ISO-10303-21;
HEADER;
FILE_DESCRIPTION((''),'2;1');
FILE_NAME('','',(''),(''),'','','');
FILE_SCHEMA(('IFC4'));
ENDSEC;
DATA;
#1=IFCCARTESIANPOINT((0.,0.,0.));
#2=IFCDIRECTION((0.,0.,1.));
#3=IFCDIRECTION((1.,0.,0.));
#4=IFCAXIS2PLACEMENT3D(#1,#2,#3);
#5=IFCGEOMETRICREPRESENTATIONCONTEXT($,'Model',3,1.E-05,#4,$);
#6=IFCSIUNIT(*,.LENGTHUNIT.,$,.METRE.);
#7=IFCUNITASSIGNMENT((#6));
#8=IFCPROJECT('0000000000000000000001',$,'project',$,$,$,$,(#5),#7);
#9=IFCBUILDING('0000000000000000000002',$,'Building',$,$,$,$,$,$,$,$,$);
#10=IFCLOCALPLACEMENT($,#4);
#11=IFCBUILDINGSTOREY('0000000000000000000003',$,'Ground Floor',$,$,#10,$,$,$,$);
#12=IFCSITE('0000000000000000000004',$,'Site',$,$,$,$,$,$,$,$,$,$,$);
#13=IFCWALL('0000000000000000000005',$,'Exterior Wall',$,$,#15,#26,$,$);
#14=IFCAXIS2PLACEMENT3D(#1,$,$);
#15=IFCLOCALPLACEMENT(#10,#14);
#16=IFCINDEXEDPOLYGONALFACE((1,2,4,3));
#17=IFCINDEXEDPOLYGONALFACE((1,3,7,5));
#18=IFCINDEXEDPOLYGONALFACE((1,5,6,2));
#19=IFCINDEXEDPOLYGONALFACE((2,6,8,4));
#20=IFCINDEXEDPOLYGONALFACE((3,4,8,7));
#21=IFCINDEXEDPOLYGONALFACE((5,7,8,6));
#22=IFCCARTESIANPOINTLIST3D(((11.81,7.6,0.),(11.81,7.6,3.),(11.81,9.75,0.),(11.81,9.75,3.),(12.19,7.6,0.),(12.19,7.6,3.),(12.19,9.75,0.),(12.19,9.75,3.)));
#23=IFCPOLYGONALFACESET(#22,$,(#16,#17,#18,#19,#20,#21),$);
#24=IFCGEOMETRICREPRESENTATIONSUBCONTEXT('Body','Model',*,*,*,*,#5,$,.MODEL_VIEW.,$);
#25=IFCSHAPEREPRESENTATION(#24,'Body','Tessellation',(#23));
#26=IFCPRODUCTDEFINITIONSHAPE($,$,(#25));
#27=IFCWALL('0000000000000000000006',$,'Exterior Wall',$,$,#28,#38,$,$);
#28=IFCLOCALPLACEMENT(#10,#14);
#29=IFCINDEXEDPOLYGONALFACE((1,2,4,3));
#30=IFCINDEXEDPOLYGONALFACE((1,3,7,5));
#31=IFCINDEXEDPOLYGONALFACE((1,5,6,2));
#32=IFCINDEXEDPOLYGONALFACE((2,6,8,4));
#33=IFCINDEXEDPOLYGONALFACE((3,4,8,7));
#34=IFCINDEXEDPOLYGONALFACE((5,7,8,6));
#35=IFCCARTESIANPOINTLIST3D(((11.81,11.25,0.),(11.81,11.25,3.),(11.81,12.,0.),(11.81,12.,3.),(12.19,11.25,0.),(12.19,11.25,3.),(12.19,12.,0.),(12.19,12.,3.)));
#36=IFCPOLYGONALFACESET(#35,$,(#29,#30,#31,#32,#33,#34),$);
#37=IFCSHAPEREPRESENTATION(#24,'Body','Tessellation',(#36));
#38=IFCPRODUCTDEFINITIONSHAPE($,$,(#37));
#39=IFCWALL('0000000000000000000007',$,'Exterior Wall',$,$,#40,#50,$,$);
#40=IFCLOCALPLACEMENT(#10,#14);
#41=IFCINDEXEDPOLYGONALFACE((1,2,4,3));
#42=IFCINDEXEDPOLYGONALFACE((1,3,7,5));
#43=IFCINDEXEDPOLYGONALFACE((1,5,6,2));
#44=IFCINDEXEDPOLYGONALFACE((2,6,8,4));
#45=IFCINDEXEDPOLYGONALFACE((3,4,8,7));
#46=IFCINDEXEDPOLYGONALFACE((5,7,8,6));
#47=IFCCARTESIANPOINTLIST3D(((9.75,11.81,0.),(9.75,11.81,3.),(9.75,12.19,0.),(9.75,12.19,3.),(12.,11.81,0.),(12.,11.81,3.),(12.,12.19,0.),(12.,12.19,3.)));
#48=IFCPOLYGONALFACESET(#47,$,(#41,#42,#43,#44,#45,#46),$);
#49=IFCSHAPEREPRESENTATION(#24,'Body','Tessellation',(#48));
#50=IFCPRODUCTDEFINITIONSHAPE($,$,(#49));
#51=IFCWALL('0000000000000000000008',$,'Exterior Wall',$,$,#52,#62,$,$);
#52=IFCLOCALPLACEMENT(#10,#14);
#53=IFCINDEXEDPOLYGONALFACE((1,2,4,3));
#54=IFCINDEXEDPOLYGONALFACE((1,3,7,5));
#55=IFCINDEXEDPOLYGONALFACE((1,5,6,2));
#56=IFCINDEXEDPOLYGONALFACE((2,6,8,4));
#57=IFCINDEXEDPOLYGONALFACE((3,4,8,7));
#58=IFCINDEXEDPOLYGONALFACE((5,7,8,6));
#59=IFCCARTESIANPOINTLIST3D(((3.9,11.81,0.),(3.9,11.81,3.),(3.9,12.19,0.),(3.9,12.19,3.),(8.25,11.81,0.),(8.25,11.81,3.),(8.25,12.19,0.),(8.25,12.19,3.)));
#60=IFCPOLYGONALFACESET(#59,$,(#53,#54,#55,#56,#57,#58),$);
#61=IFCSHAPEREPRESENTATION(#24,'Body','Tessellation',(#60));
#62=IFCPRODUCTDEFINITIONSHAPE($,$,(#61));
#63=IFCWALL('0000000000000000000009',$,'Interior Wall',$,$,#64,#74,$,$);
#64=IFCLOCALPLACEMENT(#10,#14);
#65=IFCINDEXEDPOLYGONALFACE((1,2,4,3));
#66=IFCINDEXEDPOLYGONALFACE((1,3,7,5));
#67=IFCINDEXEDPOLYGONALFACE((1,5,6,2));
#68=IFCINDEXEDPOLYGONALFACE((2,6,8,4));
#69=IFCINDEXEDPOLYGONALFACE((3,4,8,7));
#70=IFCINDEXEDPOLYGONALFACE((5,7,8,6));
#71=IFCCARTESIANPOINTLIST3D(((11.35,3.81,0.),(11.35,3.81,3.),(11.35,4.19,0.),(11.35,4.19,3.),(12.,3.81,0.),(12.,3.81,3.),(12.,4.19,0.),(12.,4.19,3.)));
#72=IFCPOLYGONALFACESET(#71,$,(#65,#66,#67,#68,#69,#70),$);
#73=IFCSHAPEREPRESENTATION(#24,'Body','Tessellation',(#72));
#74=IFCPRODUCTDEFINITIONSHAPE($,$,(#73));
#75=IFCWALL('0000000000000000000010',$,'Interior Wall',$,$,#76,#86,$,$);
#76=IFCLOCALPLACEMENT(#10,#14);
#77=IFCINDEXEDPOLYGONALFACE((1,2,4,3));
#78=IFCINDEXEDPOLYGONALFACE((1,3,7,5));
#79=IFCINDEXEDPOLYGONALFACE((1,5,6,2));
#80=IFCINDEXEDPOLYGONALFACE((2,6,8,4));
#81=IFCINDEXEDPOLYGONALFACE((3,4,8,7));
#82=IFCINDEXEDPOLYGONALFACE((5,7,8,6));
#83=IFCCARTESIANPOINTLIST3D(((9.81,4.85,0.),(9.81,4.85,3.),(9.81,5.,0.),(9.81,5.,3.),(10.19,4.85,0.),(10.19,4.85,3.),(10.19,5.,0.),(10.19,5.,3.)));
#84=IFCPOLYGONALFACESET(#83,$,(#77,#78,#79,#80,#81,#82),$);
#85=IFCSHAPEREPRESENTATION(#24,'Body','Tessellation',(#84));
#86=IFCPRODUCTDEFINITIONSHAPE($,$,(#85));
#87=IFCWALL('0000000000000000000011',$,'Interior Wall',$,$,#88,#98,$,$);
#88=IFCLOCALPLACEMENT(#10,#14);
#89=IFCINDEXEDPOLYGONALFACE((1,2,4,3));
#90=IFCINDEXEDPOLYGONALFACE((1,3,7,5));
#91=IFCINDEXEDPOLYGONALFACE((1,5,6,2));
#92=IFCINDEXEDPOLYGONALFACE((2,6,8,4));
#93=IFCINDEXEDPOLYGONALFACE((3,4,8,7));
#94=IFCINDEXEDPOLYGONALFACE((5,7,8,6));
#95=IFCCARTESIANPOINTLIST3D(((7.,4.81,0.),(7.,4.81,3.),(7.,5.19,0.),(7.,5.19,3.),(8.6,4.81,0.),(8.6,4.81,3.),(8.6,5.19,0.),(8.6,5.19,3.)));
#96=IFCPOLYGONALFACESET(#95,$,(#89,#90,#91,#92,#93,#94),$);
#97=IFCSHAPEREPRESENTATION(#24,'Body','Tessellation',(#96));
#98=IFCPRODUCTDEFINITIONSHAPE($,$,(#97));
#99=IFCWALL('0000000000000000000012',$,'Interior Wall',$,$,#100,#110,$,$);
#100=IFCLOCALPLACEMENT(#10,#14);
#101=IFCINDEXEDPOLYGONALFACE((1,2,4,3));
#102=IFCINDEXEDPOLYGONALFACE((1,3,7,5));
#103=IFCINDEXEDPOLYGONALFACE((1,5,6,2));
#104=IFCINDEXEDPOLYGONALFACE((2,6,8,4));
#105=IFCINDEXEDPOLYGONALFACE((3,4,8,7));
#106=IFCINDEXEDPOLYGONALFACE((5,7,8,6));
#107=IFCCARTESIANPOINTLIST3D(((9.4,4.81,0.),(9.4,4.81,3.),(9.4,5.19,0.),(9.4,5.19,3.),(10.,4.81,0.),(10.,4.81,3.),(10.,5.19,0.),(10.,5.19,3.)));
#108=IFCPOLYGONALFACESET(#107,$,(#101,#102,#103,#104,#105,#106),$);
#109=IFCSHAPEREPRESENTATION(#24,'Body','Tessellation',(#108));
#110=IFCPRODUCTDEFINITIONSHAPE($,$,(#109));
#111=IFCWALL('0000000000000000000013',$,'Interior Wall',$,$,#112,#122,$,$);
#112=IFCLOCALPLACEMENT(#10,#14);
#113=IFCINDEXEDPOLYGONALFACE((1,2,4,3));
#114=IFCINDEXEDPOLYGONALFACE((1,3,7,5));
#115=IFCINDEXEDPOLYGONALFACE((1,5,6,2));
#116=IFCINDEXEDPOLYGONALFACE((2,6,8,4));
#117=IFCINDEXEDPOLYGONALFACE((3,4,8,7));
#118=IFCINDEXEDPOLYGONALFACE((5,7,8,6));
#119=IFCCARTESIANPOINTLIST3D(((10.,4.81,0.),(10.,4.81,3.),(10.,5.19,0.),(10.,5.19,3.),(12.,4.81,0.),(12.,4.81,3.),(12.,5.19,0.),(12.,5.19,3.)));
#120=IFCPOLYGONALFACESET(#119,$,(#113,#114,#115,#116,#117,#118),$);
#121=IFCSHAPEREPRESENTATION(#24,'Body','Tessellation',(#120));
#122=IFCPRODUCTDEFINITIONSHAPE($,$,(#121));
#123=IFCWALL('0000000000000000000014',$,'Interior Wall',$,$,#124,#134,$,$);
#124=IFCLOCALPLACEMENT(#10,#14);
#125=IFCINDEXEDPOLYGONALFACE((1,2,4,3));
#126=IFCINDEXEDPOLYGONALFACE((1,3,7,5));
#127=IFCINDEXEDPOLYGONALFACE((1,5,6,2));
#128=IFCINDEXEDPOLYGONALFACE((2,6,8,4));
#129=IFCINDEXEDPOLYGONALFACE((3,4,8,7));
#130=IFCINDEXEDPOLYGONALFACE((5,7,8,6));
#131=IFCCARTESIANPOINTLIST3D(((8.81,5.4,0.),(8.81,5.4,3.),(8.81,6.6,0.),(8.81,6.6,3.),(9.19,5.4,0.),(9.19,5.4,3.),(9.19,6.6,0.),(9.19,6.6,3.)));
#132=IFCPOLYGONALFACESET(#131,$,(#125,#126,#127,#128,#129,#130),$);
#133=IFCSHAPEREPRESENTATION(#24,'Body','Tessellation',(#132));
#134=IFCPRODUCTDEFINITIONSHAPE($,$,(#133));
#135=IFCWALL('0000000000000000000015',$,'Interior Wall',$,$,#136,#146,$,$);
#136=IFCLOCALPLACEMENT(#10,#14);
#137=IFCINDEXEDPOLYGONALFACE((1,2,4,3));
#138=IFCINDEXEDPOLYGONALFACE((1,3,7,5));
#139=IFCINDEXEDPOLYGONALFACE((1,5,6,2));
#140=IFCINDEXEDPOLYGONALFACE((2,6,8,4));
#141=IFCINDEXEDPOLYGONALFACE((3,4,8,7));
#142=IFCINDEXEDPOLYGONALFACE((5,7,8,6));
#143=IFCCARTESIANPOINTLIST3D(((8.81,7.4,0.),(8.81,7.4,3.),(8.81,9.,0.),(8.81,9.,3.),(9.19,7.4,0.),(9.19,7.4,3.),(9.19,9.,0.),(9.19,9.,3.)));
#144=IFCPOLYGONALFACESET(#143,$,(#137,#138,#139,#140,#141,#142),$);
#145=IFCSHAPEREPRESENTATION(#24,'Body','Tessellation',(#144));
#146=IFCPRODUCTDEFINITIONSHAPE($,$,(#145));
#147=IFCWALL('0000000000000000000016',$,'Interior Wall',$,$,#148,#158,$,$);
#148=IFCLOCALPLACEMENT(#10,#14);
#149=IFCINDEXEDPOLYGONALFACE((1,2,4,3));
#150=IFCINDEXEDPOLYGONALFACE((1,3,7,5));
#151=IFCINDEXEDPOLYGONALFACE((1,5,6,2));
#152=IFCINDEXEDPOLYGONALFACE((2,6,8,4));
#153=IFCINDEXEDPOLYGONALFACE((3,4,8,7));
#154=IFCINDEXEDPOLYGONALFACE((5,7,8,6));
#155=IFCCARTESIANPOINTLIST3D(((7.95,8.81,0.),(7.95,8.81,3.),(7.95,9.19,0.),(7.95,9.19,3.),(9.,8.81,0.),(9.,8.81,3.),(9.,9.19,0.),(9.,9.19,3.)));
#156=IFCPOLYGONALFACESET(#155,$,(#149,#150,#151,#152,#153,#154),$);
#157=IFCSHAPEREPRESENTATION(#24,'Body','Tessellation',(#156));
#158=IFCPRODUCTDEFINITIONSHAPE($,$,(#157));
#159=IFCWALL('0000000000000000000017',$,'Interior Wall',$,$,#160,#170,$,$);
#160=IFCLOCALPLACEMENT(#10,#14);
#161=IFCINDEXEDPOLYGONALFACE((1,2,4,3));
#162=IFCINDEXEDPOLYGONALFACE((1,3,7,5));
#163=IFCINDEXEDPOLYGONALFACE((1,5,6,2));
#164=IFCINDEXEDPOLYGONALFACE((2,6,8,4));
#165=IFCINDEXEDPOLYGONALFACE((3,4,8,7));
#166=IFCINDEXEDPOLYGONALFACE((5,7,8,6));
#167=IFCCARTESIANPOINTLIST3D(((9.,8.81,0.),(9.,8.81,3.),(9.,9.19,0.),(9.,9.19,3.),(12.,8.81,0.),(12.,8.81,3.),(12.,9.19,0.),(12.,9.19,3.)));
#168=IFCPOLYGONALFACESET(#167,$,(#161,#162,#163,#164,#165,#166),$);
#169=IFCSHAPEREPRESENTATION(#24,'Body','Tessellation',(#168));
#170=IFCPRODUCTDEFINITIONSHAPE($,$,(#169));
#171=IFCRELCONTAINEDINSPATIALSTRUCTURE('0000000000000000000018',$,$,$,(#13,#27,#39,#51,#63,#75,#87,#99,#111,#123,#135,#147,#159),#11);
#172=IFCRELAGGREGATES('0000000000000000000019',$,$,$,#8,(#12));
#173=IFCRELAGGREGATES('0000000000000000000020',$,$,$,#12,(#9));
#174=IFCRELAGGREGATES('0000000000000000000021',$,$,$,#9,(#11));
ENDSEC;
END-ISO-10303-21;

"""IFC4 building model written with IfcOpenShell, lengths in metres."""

from ifc_helpers import new_model, si_unit, frame, origin_with_axes, place, context, subcontext, project, spatial, indexed_curve, outline, extrude, element, save


model = new_model("IFC4")

# Units and contexts
model_context = context("Model", 3, precision=1e-05, world=origin_with_axes())
body_context = subcontext(model_context, "Body", "Model", "MODEL_VIEW")
ifc_project = project(units=[si_unit("LENGTHUNIT", "METRE")], contexts=[model_context])

# Site, building, storey
site = spatial("IfcSite", under=ifc_project, Name="Site")
building = spatial("IfcBuilding", under=site, Name="Building")
storey_placement = place(None, origin_with_axes())
storey = spatial("IfcBuildingStorey", under=building, at=storey_placement, Name="Ground Floor")

# Walls
wall_1_placement = place(storey_placement, frame((12.0, 7.6, 0.0), z_axis=(0.0, 0.0, 1.0), x_axis=(0.0, 1.0, 0.0)))
element("IfcWall", 1, at=wall_1_placement, inside=storey, Name="Exterior Wall", context=body_context, shape_type="SweptSolid", body=[
    extrude(outline(indexed_curve([(0.0, 0.0), (0.0, 0.38), (2.15, 0.38), (2.15, 0.0), (0.0, 0.0)], self_intersect=False)), frame((0.0, -0.19, 0.0), z_axis=(0.0, 0.0, 1.0), x_axis=(1.0, 0.0, 0.0)), (0.0, 0.0, 1.0), 3.0),
])
wall_2_placement = place(storey_placement, frame((12.0, 11.25, 0.0), z_axis=(0.0, 0.0, 1.0), x_axis=(0.0, 1.0, 0.0)))
element("IfcWall", 2, at=wall_2_placement, inside=storey, Name="Exterior Wall", context=body_context, shape_type="SweptSolid", body=[
    extrude(outline(indexed_curve([(0.0, 0.0), (0.0, 0.38), (0.75, 0.38), (0.75, 0.0), (0.0, 0.0)], self_intersect=False)), frame((0.0, -0.19, 0.0), z_axis=(0.0, 0.0, 1.0), x_axis=(1.0, 0.0, 0.0)), (0.0, 0.0, 1.0), 3.0),
])
wall_3_placement = place(storey_placement, frame((12.0, 12.0, 0.0), z_axis=(0.0, 0.0, 1.0), x_axis=(-1.0, 0.0, 0.0)))
element("IfcWall", 3, at=wall_3_placement, inside=storey, Name="Exterior Wall", context=body_context, shape_type="SweptSolid", body=[
    extrude(outline(indexed_curve([(0.0, 0.0), (0.0, 0.38), (2.25, 0.38), (2.25, 0.0), (0.0, 0.0)], self_intersect=False)), frame((0.0, -0.19, 0.0), z_axis=(0.0, 0.0, 1.0), x_axis=(1.0, 0.0, 0.0)), (0.0, 0.0, 1.0), 3.0),
])
wall_4_placement = place(storey_placement, frame((8.25, 12.0, 0.0), z_axis=(0.0, 0.0, 1.0), x_axis=(-1.0, 0.0, 0.0)))
element("IfcWall", 4, at=wall_4_placement, inside=storey, Name="Exterior Wall", context=body_context, shape_type="SweptSolid", body=[
    extrude(outline(indexed_curve([(0.0, 0.0), (0.0, 0.38), (4.35, 0.38), (4.35, 0.0), (0.0, 0.0)], self_intersect=False)), frame((0.0, -0.19, 0.0), z_axis=(0.0, 0.0, 1.0), x_axis=(1.0, 0.0, 0.0)), (0.0, 0.0, 1.0), 3.0),
])
wall_5_placement = place(storey_placement, frame((12.0, 4.0, 0.0), z_axis=(0.0, 0.0, 1.0), x_axis=(-1.0, 0.0, 0.0)))
element("IfcWall", 5, at=wall_5_placement, inside=storey, Name="Interior Wall", context=body_context, shape_type="SweptSolid", body=[
    extrude(outline(indexed_curve([(0.0, 0.0), (0.0, 0.38), (0.65, 0.38), (0.65, 0.0), (0.0, 0.0)], self_intersect=False)), frame((0.0, -0.19, 0.0), z_axis=(0.0, 0.0, 1.0), x_axis=(1.0, 0.0, 0.0)), (0.0, 0.0, 1.0), 3.0),
])
wall_6_placement = place(storey_placement, frame((10.0, 4.85, 0.0), z_axis=(0.0, 0.0, 1.0), x_axis=(0.0, 1.0, 0.0)))
element("IfcWall", 6, at=wall_6_placement, inside=storey, Name="Interior Wall", context=body_context, shape_type="SweptSolid", body=[
    extrude(outline(indexed_curve([(0.0, 0.0), (0.0, 0.38), (0.15, 0.38), (0.15, 0.0), (0.0, 0.0)], self_intersect=False)), frame((0.0, -0.19, 0.0), z_axis=(0.0, 0.0, 1.0), x_axis=(1.0, 0.0, 0.0)), (0.0, 0.0, 1.0), 3.0),
])
wall_7_placement = place(storey_placement, frame((8.6, 5.0, 0.0), z_axis=(0.0, 0.0, 1.0), x_axis=(-1.0, 0.0, 0.0)))
element("IfcWall", 7, at=wall_7_placement, inside=storey, Name="Interior Wall", context=body_context, shape_type="SweptSolid", body=[
    extrude(outline(indexed_curve([(0.0, 0.0), (0.0, 0.38), (1.6, 0.38), (1.6, 0.0), (0.0, 0.0)], self_intersect=False)), frame((0.0, -0.19, 0.0), z_axis=(0.0, 0.0, 1.0), x_axis=(1.0, 0.0, 0.0)), (0.0, 0.0, 1.0), 3.0),
])
wall_8_placement = place(storey_placement, frame((10.0, 5.0, 0.0), z_axis=(0.0, 0.0, 1.0), x_axis=(-1.0, 0.0, 0.0)))
element("IfcWall", 8, at=wall_8_placement, inside=storey, Name="Interior Wall", context=body_context, shape_type="SweptSolid", body=[
    extrude(outline(indexed_curve([(0.0, 0.0), (0.0, 0.38), (0.6, 0.38), (0.6, 0.0), (0.0, 0.0)], self_intersect=False)), frame((0.0, -0.19, 0.0), z_axis=(0.0, 0.0, 1.0), x_axis=(1.0, 0.0, 0.0)), (0.0, 0.0, 1.0), 3.0),
])
wall_9_placement = place(storey_placement, frame((12.0, 5.0, 0.0), z_axis=(0.0, 0.0, 1.0), x_axis=(-1.0, 0.0, 0.0)))
element("IfcWall", 9, at=wall_9_placement, inside=storey, Name="Interior Wall", context=body_context, shape_type="SweptSolid", body=[
    extrude(outline(indexed_curve([(0.0, 0.0), (0.0, 0.38), (2.0, 0.38), (2.0, 0.0), (0.0, 0.0)], self_intersect=False)), frame((0.0, -0.19, 0.0), z_axis=(0.0, 0.0, 1.0), x_axis=(1.0, 0.0, 0.0)), (0.0, 0.0, 1.0), 3.0),
])
wall_10_placement = place(storey_placement, frame((9.0, 5.4, 0.0), z_axis=(0.0, 0.0, 1.0), x_axis=(0.0, 1.0, 0.0)))
element("IfcWall", 10, at=wall_10_placement, inside=storey, Name="Interior Wall", context=body_context, shape_type="SweptSolid", body=[
    extrude(outline(indexed_curve([(0.0, 0.0), (0.0, 0.38), (1.2, 0.38), (1.2, 0.0), (0.0, 0.0)], self_intersect=False)), frame((0.0, -0.19, 0.0), z_axis=(0.0, 0.0, 1.0), x_axis=(1.0, 0.0, 0.0)), (0.0, 0.0, 1.0), 3.0),
])
wall_11_placement = place(storey_placement, frame((9.0, 7.4, 0.0), z_axis=(0.0, 0.0, 1.0), x_axis=(0.0, 1.0, 0.0)))
element("IfcWall", 11, at=wall_11_placement, inside=storey, Name="Interior Wall", context=body_context, shape_type="SweptSolid", body=[
    extrude(outline(indexed_curve([(0.0, 0.0), (0.0, 0.38), (1.6, 0.38), (1.6, 0.0), (0.0, 0.0)], self_intersect=False)), frame((0.0, -0.19, 0.0), z_axis=(0.0, 0.0, 1.0), x_axis=(1.0, 0.0, 0.0)), (0.0, 0.0, 1.0), 3.0),
])
wall_12_placement = place(storey_placement, frame((9.0, 9.0, 0.0), z_axis=(0.0, 0.0, 1.0), x_axis=(-1.0, 0.0, 0.0)))
element("IfcWall", 12, at=wall_12_placement, inside=storey, Name="Interior Wall", context=body_context, shape_type="SweptSolid", body=[
    extrude(outline(indexed_curve([(0.0, 0.0), (0.0, 0.38), (1.05, 0.38), (1.05, 0.0), (0.0, 0.0)], self_intersect=False)), frame((0.0, -0.19, 0.0), z_axis=(0.0, 0.0, 1.0), x_axis=(1.0, 0.0, 0.0)), (0.0, 0.0, 1.0), 3.0),
])
wall_13_placement = place(storey_placement, frame((12.0, 9.0, 0.0), z_axis=(0.0, 0.0, 1.0), x_axis=(-1.0, 0.0, 0.0)))
element("IfcWall", 13, at=wall_13_placement, inside=storey, Name="Interior Wall", context=body_context, shape_type="SweptSolid", body=[
    extrude(outline(indexed_curve([(0.0, 0.0), (0.0, 0.38), (3.0, 0.38), (3.0, 0.0), (0.0, 0.0)], self_intersect=False)), frame((0.0, -0.19, 0.0), z_axis=(0.0, 0.0, 1.0), x_axis=(1.0, 0.0, 0.0)), (0.0, 0.0, 1.0), 3.0),
])

save(model, "model.ifc")
